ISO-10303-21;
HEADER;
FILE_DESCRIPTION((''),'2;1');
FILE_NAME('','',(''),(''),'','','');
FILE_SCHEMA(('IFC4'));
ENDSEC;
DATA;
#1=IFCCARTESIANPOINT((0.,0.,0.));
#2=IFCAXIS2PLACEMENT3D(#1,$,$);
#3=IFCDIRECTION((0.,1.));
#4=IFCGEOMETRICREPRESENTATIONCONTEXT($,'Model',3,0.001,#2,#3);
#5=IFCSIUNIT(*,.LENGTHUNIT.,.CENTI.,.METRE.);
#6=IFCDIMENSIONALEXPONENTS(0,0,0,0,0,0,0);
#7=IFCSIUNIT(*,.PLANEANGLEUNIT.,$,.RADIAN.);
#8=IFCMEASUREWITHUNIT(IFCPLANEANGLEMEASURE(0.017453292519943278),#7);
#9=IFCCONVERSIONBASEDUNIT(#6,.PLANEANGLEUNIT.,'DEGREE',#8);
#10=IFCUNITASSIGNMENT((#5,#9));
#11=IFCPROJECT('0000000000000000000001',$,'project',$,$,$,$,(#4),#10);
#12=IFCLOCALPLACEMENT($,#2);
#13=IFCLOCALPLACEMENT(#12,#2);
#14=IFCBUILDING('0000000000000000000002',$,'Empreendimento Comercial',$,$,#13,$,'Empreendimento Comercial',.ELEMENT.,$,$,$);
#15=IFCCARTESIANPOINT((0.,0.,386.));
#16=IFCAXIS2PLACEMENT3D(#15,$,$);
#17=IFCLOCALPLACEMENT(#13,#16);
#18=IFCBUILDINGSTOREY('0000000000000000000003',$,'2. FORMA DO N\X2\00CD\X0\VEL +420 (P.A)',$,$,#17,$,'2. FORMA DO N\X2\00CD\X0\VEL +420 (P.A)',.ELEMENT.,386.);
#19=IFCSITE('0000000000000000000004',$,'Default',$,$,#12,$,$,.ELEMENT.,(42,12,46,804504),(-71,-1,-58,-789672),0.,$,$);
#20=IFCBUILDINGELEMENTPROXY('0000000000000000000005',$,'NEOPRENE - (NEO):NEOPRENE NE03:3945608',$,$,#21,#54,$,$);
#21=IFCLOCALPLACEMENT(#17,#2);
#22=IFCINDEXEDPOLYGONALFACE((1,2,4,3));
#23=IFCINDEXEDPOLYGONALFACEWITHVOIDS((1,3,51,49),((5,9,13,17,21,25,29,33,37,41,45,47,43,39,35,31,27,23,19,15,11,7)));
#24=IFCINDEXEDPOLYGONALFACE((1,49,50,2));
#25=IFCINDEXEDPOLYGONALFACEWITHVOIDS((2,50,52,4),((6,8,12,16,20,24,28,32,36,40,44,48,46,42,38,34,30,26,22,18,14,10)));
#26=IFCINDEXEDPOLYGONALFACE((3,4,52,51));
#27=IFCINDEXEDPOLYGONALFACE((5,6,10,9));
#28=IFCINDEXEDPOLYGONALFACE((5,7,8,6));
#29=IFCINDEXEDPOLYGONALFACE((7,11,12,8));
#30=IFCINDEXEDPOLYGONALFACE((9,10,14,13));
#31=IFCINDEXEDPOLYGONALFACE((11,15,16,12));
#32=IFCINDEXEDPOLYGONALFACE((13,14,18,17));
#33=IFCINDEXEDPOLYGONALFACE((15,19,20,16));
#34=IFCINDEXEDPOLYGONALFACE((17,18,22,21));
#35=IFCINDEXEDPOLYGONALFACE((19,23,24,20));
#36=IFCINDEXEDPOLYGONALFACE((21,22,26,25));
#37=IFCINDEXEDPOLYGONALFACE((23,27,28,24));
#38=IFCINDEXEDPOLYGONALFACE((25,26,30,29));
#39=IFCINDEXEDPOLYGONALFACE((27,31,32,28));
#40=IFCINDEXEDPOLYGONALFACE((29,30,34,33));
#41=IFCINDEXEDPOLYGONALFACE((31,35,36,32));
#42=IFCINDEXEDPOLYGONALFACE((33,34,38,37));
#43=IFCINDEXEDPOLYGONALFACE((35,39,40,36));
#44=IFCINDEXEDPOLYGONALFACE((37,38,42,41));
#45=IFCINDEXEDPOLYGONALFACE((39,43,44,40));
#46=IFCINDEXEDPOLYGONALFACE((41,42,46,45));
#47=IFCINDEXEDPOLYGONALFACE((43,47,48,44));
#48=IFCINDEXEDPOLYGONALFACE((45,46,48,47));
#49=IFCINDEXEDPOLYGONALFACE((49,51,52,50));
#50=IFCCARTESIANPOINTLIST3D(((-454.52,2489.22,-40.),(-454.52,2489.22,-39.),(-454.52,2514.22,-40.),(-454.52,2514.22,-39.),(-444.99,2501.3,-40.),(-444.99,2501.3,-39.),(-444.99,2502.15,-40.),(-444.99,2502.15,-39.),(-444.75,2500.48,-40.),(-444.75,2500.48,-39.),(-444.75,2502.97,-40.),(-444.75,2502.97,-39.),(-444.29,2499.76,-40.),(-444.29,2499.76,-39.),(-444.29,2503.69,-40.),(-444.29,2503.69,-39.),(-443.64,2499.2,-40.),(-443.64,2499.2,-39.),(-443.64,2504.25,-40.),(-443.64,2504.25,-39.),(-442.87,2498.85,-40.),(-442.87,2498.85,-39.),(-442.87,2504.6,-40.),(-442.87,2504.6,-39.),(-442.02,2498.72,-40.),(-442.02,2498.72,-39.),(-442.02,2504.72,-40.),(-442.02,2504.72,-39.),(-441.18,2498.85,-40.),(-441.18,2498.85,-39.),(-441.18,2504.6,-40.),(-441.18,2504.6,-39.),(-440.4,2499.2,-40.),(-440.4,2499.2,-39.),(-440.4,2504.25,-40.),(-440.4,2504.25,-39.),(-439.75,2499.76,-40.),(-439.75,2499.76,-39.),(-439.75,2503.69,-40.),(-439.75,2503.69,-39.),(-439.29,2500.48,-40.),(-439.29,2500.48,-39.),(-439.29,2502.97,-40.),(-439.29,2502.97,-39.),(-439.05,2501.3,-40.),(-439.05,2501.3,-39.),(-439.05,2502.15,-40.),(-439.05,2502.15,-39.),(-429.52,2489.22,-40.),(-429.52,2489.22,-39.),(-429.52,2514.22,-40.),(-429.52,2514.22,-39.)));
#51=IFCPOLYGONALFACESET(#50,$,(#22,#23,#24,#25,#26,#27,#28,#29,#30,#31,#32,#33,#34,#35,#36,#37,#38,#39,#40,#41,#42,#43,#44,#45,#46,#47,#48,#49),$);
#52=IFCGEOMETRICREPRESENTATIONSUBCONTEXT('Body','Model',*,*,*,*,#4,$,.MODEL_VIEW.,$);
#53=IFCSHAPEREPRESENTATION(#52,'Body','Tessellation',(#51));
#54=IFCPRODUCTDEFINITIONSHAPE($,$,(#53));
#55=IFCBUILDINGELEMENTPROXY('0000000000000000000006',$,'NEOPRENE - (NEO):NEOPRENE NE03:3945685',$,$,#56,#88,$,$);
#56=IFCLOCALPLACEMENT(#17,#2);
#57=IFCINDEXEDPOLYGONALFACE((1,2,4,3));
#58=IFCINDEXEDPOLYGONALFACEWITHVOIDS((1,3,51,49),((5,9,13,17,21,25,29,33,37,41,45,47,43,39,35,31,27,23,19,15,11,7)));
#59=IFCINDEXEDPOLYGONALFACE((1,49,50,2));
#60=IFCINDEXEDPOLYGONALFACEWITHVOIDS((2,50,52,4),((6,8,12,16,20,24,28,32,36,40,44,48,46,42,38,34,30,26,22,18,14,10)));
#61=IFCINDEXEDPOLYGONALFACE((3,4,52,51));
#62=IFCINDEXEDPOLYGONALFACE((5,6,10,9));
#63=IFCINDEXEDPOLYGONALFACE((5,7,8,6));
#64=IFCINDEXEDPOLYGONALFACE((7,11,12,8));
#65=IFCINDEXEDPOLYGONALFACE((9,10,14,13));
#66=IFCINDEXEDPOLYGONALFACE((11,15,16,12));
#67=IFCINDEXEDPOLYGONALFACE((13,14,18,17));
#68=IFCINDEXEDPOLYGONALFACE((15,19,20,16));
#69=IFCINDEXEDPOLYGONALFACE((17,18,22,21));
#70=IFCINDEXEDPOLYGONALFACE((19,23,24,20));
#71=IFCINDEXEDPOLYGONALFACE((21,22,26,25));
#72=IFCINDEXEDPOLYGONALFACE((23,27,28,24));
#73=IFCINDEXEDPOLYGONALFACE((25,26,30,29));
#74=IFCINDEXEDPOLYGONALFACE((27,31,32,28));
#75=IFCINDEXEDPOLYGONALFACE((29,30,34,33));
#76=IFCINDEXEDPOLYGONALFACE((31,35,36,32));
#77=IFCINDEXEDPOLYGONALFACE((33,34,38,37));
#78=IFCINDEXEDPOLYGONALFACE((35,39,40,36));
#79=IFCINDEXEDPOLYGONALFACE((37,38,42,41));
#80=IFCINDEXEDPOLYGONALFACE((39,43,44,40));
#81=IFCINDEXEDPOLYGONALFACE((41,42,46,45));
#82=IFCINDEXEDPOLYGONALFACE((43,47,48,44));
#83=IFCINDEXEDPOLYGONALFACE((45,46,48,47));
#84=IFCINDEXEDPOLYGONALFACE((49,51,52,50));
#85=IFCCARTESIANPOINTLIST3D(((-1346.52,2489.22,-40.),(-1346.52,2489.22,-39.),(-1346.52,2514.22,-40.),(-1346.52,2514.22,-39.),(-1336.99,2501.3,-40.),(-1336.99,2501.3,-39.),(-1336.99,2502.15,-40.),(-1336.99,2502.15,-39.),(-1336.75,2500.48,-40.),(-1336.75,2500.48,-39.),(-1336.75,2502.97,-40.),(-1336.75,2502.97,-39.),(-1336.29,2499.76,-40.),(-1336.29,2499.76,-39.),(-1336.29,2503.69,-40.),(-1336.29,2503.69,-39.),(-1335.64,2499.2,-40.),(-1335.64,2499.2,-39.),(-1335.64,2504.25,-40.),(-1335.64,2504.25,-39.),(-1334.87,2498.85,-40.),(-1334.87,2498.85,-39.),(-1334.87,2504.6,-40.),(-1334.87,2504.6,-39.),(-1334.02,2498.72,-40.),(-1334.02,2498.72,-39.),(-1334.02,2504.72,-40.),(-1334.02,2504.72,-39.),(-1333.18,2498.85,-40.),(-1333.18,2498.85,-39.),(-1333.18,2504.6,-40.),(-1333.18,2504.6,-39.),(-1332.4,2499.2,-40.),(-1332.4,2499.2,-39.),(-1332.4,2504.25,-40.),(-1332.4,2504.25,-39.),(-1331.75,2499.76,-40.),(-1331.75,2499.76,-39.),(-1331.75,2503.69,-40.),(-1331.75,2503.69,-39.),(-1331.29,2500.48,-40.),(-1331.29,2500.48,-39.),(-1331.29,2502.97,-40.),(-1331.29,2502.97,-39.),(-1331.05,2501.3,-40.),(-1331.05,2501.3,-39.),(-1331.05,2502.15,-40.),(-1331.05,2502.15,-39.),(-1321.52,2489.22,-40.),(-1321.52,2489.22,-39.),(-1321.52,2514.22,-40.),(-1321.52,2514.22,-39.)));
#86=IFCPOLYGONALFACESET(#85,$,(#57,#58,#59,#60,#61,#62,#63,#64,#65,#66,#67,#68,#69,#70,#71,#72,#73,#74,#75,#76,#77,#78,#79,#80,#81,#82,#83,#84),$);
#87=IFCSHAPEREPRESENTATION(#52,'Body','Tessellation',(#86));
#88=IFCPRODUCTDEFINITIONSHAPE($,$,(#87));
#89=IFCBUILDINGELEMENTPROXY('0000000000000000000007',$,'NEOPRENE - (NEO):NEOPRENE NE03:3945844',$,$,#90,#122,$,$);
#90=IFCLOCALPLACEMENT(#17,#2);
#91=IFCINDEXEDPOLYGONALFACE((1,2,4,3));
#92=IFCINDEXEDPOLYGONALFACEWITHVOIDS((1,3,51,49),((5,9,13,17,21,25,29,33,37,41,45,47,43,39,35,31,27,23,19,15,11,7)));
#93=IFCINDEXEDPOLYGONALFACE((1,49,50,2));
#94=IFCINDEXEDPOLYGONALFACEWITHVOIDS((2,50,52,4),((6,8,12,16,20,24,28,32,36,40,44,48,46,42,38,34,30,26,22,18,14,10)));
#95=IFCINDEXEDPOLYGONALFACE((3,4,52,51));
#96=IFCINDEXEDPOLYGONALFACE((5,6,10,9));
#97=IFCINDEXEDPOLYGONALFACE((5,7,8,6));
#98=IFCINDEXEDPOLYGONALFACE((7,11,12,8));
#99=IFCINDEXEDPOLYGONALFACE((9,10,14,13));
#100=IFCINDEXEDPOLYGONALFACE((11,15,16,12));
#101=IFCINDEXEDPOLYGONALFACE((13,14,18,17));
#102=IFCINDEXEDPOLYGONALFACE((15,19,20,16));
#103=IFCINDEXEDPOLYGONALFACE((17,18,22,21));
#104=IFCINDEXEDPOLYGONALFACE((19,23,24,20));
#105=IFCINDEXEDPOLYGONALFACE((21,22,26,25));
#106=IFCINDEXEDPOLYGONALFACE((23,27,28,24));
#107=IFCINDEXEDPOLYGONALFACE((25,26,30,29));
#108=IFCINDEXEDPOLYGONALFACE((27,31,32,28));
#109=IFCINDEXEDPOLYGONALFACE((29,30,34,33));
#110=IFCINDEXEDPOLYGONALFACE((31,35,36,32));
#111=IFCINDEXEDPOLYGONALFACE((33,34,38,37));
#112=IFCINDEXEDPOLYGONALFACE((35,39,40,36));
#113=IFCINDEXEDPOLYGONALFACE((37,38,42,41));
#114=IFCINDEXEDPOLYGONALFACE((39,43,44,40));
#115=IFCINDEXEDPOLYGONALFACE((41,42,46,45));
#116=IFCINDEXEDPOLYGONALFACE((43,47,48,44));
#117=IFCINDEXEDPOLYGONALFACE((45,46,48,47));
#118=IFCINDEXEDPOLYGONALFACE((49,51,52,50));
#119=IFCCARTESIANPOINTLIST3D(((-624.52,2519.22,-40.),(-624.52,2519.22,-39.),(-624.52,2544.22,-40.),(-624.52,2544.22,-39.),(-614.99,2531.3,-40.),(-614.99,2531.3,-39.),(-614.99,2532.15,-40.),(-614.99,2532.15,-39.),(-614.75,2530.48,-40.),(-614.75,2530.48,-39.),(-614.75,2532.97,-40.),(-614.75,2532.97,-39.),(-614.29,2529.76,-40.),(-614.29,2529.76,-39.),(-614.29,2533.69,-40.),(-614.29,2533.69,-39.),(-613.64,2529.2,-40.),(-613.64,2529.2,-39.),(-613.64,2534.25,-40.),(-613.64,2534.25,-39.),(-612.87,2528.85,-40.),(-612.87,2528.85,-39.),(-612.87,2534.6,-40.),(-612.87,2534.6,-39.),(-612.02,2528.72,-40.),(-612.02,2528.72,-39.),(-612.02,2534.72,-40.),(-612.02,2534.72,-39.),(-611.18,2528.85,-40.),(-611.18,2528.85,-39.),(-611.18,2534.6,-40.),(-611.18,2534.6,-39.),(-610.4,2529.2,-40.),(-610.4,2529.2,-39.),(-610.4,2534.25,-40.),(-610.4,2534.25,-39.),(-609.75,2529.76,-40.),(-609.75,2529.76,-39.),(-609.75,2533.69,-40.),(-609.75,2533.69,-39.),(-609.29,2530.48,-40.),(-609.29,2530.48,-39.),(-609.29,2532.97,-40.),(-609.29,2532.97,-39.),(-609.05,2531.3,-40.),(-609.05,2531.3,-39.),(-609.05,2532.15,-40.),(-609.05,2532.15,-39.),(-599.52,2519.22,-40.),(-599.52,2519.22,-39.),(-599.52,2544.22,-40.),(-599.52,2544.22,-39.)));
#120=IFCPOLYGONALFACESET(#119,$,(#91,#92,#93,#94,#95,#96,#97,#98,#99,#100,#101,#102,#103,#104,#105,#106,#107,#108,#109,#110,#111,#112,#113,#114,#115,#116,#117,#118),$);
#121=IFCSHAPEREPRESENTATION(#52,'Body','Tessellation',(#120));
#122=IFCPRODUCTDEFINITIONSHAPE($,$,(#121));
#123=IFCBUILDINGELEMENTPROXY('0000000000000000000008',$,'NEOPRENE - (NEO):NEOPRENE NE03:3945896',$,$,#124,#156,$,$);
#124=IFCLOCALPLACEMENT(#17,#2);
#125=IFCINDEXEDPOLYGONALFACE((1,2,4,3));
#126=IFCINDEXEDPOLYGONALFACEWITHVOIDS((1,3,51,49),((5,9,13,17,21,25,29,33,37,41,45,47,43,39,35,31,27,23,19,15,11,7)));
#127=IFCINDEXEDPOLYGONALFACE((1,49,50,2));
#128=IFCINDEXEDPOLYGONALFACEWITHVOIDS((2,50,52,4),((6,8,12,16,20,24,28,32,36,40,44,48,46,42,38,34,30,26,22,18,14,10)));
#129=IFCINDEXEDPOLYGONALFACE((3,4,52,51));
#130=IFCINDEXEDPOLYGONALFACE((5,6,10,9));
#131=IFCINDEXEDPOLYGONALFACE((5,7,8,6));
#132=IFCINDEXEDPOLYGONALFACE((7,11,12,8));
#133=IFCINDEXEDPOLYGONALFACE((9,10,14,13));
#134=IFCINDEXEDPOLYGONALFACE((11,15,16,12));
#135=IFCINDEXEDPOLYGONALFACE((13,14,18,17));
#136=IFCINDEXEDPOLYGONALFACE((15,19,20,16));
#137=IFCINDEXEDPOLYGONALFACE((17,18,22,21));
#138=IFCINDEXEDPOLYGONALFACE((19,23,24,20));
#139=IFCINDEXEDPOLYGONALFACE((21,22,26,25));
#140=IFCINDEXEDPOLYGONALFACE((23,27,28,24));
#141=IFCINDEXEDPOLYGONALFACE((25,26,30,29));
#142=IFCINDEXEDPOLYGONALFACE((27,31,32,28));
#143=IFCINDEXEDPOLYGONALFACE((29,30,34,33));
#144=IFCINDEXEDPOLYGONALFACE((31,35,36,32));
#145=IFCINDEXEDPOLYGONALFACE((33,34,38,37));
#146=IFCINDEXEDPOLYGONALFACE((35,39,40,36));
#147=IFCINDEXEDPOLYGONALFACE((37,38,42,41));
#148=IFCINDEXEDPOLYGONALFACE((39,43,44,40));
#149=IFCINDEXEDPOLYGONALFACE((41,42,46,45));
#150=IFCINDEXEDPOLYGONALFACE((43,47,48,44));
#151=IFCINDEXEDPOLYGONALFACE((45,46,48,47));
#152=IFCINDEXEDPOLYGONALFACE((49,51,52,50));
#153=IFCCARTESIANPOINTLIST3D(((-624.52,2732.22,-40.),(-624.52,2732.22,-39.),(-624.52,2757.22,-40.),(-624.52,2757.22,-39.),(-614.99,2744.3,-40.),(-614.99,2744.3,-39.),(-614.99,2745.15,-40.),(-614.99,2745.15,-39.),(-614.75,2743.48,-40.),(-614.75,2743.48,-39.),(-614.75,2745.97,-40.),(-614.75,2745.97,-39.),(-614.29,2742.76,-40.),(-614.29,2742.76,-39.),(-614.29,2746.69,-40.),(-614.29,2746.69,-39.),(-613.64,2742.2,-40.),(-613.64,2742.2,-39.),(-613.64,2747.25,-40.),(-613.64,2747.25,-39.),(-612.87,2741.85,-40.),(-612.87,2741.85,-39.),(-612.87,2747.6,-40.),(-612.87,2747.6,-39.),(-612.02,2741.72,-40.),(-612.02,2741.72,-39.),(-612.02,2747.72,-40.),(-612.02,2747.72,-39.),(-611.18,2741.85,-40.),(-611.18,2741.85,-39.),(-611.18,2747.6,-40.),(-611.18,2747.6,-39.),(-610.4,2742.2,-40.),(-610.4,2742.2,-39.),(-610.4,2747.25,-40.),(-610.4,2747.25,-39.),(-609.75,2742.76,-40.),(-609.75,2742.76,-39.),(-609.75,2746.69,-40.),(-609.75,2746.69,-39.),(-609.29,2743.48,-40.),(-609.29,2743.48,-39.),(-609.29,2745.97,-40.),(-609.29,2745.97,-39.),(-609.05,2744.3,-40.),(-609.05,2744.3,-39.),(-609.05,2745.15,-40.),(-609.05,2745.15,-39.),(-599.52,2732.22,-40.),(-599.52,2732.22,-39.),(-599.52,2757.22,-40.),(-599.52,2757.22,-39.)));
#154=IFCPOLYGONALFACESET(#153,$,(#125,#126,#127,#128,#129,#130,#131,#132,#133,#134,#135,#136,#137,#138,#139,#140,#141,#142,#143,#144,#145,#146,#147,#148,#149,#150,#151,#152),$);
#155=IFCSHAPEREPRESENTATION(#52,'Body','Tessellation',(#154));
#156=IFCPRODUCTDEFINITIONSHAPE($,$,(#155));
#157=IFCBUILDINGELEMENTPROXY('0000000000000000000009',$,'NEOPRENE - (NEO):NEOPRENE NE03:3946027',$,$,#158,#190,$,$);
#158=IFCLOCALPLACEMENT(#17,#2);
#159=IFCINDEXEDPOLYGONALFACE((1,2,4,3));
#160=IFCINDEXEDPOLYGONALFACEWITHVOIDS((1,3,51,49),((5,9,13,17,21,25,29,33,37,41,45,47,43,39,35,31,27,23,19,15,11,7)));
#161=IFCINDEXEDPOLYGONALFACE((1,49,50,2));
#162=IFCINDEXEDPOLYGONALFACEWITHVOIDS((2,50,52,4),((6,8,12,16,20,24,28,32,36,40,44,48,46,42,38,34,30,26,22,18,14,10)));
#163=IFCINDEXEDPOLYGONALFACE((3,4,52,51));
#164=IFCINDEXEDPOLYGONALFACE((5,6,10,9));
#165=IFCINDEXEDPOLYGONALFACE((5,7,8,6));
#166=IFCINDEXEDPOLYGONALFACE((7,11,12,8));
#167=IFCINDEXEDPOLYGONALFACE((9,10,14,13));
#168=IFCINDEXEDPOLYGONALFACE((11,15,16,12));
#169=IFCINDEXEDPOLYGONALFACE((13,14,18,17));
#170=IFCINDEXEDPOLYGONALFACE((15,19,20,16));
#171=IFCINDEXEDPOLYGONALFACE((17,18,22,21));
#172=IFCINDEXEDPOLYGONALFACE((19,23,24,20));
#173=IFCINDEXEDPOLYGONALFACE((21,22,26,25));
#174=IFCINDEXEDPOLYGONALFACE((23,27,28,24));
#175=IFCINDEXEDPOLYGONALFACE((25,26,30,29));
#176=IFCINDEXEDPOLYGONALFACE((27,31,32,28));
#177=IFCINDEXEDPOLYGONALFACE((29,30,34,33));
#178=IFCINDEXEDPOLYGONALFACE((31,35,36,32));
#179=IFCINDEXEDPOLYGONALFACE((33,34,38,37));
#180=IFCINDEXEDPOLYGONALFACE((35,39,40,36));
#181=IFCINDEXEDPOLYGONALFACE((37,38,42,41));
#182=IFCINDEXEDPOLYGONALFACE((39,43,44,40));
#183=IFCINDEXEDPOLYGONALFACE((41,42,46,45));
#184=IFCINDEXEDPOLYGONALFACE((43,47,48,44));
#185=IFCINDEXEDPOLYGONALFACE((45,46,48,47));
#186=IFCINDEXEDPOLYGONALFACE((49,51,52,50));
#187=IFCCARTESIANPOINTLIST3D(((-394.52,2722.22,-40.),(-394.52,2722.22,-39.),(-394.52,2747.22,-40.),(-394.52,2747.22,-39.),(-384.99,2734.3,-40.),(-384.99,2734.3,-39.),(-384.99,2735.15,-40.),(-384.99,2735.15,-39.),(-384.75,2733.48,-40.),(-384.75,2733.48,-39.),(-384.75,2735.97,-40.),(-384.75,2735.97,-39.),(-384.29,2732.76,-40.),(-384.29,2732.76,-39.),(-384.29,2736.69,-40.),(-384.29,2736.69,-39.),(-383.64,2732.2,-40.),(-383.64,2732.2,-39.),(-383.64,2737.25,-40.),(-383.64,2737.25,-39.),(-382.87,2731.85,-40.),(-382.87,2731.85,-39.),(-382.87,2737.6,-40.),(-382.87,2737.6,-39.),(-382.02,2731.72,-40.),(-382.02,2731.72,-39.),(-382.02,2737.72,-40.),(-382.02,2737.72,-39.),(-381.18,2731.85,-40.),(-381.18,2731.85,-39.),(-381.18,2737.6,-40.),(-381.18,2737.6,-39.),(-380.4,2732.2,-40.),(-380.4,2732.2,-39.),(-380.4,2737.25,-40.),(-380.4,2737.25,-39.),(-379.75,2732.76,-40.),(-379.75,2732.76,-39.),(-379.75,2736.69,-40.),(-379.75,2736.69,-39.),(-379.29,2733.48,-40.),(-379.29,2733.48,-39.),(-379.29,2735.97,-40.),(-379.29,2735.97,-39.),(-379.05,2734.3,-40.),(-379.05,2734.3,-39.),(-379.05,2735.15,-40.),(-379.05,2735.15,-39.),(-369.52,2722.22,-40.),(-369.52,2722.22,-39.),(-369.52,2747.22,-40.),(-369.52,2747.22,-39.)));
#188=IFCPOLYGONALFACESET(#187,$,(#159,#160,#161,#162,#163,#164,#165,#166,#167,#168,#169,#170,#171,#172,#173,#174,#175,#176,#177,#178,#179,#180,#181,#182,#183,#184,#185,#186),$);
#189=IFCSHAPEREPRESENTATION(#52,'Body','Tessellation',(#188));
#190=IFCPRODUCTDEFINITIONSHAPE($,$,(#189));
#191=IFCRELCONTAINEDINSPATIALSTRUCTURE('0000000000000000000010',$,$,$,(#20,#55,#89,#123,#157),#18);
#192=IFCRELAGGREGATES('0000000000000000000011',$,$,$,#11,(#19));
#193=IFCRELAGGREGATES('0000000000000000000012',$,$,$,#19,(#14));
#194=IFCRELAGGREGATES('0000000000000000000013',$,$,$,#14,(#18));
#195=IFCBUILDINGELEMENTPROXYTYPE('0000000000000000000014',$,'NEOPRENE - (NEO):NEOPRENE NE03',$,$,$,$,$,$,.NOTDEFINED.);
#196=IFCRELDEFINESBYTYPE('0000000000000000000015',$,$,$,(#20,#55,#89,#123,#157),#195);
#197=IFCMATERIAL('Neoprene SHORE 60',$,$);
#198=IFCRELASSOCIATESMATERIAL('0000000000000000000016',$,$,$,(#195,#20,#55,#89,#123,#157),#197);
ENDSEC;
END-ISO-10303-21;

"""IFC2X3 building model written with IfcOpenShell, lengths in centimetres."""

from ifc_helpers import new_model, entity, si_unit, converted_unit, direction, frame, frame_2d, origin, place, context, subcontext, project, spatial, polyline, circle_curve, parameter, trimmed, segment, composite_curve, outline, extrude, source, transform, mapped, material, type_object, type_shapes, element, save


model = new_model("IFC2X3")

# Units and contexts
model_context = context("Model", 3, precision=0.001, world=origin(), true_north=direction((0.0, 1.0)))
body_context = subcontext(model_context, "Body", "Model", "MODEL_VIEW")
ifc_project = project(units=[si_unit("LENGTHUNIT", "METRE", prefix="CENTI"), converted_unit("PLANEANGLEUNIT", "DEGREE", entity("IfcPlaneAngleMeasure", 0.017453292519943278), si_unit("PLANEANGLEUNIT", "RADIAN"), dimensions=[0, 0, 0, 0, 0, 0, 0])], contexts=[model_context])

# Site, building, storey
site_placement = place(None, origin())
site = spatial("IfcSite", under=ifc_project, at=site_placement, Name="Default", CompositionType="ELEMENT", RefLatitude=(42, 12, 46, 804504), RefLongitude=(-71, -1, -58, -789672), RefElevation=0.0)
building_placement = place(site_placement, origin())
building = spatial("IfcBuilding", under=site, at=building_placement, Name="Empreendimento Comercial", LongName="Empreendimento Comercial", CompositionType="ELEMENT")
storey_placement = place(building_placement, frame((0.0, 0.0, 386.0)))
storey = spatial("IfcBuildingStorey", under=building, at=storey_placement, Name="2. FORMA DO NÍVEL +420 (P.A)", LongName="2. FORMA DO NÍVEL +420 (P.A)", CompositionType="ELEMENT", Elevation=386.0)

# Building element proxies
ifc_material = material(Name="Neoprene SHORE 60")
building_element_proxy_type_1 = type_object("IfcBuildingElementProxyType", Name="NEOPRENE - (NEO):NEOPRENE NE03", PredefinedType="NOTDEFINED", material=ifc_material)
shared_shape_1 = source(origin(), body_context, "Body", "SweptSolid", [
    extrude(outline(polyline([(-12.5, -12.5), (12.5, -12.5), (12.5, 12.5), (-12.5, 12.5), (-12.5, -12.5)]), holes=[composite_curve([segment(trimmed(circle_curve(frame_2d((0.0, 0.0), x_axis=(-1.0, 0.0)), 3.0), [parameter(0.0)], [parameter(180.0)], True, "PARAMETER"), False, "CONTINUOUS"), segment(trimmed(circle_curve(frame_2d((0.0, 0.0), x_axis=(-1.0, 0.0)), 3.0), [parameter(180.0)], [parameter(0.0)], True, "PARAMETER"), False, "CONTINUOUS")], self_intersect=False)]), frame((0.0, 0.0, -71.0), z_axis=(0.0, 0.0, 1.0), x_axis=(-1.0, 0.0, 0.0)), (0.0, 0.0, 1.0), 1.0),
])
type_shapes(building_element_proxy_type_1, [shared_shape_1])
for number, where, z_axis, x_axis, name in (
    (1, (-442.02, 2501.72, 31.0), (0.0, 0.0, 1.0), (0.0, -1.0, 0.0), "NEOPRENE - (NEO):NEOPRENE NE03:3945608"),
    (2, (-1334.02, 2501.72, 31.0), (0.0, 0.0, 1.0), (0.0, -1.0, 0.0), "NEOPRENE - (NEO):NEOPRENE NE03:3945685"),
    (3, (-612.02, 2531.72, 31.0), (0.0, 0.0, 1.0), (0.0, -1.0, 0.0), "NEOPRENE - (NEO):NEOPRENE NE03:3945844"),
    (4, (-612.02, 2744.72, 31.0), (0.0, 0.0, 1.0), (0.0, -1.0, 0.0), "NEOPRENE - (NEO):NEOPRENE NE03:3945896"),
    (5, (-382.02, 2734.72, 31.0), (0.0, 0.0, 1.0), (0.0, -1.0, 0.0), "NEOPRENE - (NEO):NEOPRENE NE03:3946027"),
):
    element("IfcBuildingElementProxy", number, at=place(storey_placement, frame(where, z_axis=z_axis, x_axis=x_axis)), inside=storey, type_object=building_element_proxy_type_1, material=ifc_material, Name=name, context=body_context, shape_type="MappedRepresentation", body=[
        mapped(shared_shape_1, transform((0.0, 0.0, 0.0), scale=1.0)),
    ])

save(model, "model.ifc")
